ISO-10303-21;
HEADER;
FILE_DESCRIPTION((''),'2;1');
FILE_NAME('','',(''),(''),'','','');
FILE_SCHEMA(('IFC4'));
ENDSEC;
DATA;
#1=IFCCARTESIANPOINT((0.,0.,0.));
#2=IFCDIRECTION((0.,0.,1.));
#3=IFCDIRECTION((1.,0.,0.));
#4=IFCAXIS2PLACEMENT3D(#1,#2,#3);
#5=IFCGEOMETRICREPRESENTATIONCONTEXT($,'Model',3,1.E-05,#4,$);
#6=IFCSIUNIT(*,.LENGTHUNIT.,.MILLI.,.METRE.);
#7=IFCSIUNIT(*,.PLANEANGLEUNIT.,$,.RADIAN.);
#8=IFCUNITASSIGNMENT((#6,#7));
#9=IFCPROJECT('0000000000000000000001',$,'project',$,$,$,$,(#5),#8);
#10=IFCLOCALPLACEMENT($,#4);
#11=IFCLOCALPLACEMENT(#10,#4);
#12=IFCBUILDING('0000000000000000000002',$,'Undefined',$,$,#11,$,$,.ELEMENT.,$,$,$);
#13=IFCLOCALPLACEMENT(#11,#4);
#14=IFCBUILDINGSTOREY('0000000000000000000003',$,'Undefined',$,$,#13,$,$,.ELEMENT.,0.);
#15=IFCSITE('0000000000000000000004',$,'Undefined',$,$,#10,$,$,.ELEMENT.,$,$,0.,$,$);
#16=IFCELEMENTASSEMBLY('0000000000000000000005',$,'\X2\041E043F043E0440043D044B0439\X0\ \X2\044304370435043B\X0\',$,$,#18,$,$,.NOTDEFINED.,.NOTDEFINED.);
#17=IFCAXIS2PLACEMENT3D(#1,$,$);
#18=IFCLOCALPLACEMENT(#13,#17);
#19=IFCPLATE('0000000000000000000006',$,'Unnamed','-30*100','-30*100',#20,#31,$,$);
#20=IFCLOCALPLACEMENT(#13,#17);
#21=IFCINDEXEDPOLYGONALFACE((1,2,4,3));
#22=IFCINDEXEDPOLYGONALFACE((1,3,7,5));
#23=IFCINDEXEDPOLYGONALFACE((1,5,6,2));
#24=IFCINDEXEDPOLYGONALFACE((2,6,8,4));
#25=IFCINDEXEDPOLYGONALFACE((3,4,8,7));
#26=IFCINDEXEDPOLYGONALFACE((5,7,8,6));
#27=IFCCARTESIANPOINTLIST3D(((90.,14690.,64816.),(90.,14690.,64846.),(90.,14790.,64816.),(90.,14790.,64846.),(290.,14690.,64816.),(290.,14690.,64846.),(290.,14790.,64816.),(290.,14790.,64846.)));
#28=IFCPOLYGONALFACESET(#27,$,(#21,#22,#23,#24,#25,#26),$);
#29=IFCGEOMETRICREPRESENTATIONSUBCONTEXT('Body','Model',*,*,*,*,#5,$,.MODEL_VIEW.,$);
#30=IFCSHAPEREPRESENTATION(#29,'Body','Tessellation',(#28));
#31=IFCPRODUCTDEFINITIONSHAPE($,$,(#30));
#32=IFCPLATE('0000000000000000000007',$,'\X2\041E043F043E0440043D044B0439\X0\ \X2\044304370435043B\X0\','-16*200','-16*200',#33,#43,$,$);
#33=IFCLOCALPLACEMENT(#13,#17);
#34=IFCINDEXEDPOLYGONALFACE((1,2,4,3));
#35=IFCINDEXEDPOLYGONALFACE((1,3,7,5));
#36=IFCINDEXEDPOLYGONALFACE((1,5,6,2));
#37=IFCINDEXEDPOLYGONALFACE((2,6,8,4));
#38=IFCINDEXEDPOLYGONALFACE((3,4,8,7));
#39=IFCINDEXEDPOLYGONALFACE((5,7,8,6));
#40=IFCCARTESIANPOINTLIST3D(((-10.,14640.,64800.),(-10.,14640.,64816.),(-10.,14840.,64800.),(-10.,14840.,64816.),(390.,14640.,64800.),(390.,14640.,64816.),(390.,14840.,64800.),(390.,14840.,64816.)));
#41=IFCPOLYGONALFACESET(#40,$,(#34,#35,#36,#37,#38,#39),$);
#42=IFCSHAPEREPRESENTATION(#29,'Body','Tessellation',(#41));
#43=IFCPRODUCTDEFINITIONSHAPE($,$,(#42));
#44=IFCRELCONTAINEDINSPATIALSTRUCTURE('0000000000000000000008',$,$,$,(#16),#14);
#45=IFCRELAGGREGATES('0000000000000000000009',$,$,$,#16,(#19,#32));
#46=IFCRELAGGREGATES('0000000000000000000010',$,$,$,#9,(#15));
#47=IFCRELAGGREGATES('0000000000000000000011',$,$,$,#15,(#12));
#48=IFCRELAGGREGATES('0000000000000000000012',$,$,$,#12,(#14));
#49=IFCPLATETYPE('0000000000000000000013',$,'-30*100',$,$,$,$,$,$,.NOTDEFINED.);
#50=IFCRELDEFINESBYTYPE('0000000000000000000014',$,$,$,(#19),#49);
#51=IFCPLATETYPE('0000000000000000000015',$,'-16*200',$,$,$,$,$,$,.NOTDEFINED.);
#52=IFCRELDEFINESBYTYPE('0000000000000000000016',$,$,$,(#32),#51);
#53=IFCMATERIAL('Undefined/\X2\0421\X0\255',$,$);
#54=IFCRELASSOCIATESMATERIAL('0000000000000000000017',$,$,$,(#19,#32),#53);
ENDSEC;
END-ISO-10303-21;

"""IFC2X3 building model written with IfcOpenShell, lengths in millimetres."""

from ifc_helpers import new_model, si_unit, frame, origin_with_axes, place, context, subcontext, project, spatial, polyline, outline, extrude, material, type_object, element, aggregate, save


model = new_model("IFC2X3")

# Units and contexts
model_context = context("Model", 3, precision=1e-05, world=origin_with_axes())
body_context = subcontext(model_context, "Body", "Model", "MODEL_VIEW")
ifc_project = project(units=[si_unit("LENGTHUNIT", "METRE", prefix="MILLI"), si_unit("PLANEANGLEUNIT", "RADIAN")], contexts=[model_context])

# Site, building, storey
site_placement = place(None, origin_with_axes())
site = spatial("IfcSite", under=ifc_project, at=site_placement, Name="Undefined", CompositionType="ELEMENT", RefElevation=0.0)
building_placement = place(site_placement, origin_with_axes())
building = spatial("IfcBuilding", under=site, at=building_placement, Name="Undefined", CompositionType="ELEMENT")
storey_placement = place(building_placement, origin_with_axes())
storey = spatial("IfcBuildingStorey", under=building, at=storey_placement, Name="Undefined", CompositionType="ELEMENT", Elevation=0.0)

# Shared definitions
ifc_material_1 = material(Name="Undefined/С255")

# Element assembly
assembly_1_placement = place(storey_placement, origin_with_axes())
assembly_1 = element("IfcElementAssembly", 1, at=assembly_1_placement, inside=storey, Name="Опорный узел", AssemblyPlace="NOTDEFINED", PredefinedType="NOTDEFINED")

# Plates
plate_type_1 = type_object("IfcPlateType", Name="-30*100", PredefinedType="NOTDEFINED")
plate_1_placement = place(assembly_1_placement, frame((290.0, 14790.0, 64831.0), z_axis=(0.0, 0.0, 1.0), x_axis=(-1.0, 0.0, 0.0)))
plate_1 = element("IfcPlate", 2, at=plate_1_placement, type_object=plate_type_1, material=ifc_material_1, Name="Unnamed", Description="-30*100", ObjectType="-30*100", context=body_context, shape_type="SweptSolid", body=[
    extrude(outline(polyline([(0.0, 0.0), (200.0, 0.0), (200.0, 100.0), (0.0, 100.0), (0.0, 0.0)])), frame((0.0, 0.0, -15.0), z_axis=(0.0, 0.0, 1.0), x_axis=(1.0, 0.0, 0.0)), (0.0, 0.0, 1.0), 30.0),
])
plate_type_2 = type_object("IfcPlateType", Name="-16*200", PredefinedType="NOTDEFINED")
plate_2_placement = place(assembly_1_placement, frame((390.0, 14840.0, 64808.0), z_axis=(0.0, 0.0, 1.0), x_axis=(-1.0, 0.0, 0.0)))
plate_2 = element("IfcPlate", 3, at=plate_2_placement, type_object=plate_type_2, material=ifc_material_1, Name="Опорный узел", Description="-16*200", ObjectType="-16*200", context=body_context, shape_type="SweptSolid", body=[
    extrude(outline(polyline([(0.0, 0.0), (400.0, 0.0), (400.0, 200.0), (0.0, 200.0), (0.0, 0.0)])), frame((0.0, 0.0, -8.0), z_axis=(0.0, 0.0, 1.0), x_axis=(1.0, 0.0, 0.0)), (0.0, 0.0, 1.0), 16.0),
])

aggregate(assembly_1, [plate_1, plate_2])

save(model, "model.ifc")
